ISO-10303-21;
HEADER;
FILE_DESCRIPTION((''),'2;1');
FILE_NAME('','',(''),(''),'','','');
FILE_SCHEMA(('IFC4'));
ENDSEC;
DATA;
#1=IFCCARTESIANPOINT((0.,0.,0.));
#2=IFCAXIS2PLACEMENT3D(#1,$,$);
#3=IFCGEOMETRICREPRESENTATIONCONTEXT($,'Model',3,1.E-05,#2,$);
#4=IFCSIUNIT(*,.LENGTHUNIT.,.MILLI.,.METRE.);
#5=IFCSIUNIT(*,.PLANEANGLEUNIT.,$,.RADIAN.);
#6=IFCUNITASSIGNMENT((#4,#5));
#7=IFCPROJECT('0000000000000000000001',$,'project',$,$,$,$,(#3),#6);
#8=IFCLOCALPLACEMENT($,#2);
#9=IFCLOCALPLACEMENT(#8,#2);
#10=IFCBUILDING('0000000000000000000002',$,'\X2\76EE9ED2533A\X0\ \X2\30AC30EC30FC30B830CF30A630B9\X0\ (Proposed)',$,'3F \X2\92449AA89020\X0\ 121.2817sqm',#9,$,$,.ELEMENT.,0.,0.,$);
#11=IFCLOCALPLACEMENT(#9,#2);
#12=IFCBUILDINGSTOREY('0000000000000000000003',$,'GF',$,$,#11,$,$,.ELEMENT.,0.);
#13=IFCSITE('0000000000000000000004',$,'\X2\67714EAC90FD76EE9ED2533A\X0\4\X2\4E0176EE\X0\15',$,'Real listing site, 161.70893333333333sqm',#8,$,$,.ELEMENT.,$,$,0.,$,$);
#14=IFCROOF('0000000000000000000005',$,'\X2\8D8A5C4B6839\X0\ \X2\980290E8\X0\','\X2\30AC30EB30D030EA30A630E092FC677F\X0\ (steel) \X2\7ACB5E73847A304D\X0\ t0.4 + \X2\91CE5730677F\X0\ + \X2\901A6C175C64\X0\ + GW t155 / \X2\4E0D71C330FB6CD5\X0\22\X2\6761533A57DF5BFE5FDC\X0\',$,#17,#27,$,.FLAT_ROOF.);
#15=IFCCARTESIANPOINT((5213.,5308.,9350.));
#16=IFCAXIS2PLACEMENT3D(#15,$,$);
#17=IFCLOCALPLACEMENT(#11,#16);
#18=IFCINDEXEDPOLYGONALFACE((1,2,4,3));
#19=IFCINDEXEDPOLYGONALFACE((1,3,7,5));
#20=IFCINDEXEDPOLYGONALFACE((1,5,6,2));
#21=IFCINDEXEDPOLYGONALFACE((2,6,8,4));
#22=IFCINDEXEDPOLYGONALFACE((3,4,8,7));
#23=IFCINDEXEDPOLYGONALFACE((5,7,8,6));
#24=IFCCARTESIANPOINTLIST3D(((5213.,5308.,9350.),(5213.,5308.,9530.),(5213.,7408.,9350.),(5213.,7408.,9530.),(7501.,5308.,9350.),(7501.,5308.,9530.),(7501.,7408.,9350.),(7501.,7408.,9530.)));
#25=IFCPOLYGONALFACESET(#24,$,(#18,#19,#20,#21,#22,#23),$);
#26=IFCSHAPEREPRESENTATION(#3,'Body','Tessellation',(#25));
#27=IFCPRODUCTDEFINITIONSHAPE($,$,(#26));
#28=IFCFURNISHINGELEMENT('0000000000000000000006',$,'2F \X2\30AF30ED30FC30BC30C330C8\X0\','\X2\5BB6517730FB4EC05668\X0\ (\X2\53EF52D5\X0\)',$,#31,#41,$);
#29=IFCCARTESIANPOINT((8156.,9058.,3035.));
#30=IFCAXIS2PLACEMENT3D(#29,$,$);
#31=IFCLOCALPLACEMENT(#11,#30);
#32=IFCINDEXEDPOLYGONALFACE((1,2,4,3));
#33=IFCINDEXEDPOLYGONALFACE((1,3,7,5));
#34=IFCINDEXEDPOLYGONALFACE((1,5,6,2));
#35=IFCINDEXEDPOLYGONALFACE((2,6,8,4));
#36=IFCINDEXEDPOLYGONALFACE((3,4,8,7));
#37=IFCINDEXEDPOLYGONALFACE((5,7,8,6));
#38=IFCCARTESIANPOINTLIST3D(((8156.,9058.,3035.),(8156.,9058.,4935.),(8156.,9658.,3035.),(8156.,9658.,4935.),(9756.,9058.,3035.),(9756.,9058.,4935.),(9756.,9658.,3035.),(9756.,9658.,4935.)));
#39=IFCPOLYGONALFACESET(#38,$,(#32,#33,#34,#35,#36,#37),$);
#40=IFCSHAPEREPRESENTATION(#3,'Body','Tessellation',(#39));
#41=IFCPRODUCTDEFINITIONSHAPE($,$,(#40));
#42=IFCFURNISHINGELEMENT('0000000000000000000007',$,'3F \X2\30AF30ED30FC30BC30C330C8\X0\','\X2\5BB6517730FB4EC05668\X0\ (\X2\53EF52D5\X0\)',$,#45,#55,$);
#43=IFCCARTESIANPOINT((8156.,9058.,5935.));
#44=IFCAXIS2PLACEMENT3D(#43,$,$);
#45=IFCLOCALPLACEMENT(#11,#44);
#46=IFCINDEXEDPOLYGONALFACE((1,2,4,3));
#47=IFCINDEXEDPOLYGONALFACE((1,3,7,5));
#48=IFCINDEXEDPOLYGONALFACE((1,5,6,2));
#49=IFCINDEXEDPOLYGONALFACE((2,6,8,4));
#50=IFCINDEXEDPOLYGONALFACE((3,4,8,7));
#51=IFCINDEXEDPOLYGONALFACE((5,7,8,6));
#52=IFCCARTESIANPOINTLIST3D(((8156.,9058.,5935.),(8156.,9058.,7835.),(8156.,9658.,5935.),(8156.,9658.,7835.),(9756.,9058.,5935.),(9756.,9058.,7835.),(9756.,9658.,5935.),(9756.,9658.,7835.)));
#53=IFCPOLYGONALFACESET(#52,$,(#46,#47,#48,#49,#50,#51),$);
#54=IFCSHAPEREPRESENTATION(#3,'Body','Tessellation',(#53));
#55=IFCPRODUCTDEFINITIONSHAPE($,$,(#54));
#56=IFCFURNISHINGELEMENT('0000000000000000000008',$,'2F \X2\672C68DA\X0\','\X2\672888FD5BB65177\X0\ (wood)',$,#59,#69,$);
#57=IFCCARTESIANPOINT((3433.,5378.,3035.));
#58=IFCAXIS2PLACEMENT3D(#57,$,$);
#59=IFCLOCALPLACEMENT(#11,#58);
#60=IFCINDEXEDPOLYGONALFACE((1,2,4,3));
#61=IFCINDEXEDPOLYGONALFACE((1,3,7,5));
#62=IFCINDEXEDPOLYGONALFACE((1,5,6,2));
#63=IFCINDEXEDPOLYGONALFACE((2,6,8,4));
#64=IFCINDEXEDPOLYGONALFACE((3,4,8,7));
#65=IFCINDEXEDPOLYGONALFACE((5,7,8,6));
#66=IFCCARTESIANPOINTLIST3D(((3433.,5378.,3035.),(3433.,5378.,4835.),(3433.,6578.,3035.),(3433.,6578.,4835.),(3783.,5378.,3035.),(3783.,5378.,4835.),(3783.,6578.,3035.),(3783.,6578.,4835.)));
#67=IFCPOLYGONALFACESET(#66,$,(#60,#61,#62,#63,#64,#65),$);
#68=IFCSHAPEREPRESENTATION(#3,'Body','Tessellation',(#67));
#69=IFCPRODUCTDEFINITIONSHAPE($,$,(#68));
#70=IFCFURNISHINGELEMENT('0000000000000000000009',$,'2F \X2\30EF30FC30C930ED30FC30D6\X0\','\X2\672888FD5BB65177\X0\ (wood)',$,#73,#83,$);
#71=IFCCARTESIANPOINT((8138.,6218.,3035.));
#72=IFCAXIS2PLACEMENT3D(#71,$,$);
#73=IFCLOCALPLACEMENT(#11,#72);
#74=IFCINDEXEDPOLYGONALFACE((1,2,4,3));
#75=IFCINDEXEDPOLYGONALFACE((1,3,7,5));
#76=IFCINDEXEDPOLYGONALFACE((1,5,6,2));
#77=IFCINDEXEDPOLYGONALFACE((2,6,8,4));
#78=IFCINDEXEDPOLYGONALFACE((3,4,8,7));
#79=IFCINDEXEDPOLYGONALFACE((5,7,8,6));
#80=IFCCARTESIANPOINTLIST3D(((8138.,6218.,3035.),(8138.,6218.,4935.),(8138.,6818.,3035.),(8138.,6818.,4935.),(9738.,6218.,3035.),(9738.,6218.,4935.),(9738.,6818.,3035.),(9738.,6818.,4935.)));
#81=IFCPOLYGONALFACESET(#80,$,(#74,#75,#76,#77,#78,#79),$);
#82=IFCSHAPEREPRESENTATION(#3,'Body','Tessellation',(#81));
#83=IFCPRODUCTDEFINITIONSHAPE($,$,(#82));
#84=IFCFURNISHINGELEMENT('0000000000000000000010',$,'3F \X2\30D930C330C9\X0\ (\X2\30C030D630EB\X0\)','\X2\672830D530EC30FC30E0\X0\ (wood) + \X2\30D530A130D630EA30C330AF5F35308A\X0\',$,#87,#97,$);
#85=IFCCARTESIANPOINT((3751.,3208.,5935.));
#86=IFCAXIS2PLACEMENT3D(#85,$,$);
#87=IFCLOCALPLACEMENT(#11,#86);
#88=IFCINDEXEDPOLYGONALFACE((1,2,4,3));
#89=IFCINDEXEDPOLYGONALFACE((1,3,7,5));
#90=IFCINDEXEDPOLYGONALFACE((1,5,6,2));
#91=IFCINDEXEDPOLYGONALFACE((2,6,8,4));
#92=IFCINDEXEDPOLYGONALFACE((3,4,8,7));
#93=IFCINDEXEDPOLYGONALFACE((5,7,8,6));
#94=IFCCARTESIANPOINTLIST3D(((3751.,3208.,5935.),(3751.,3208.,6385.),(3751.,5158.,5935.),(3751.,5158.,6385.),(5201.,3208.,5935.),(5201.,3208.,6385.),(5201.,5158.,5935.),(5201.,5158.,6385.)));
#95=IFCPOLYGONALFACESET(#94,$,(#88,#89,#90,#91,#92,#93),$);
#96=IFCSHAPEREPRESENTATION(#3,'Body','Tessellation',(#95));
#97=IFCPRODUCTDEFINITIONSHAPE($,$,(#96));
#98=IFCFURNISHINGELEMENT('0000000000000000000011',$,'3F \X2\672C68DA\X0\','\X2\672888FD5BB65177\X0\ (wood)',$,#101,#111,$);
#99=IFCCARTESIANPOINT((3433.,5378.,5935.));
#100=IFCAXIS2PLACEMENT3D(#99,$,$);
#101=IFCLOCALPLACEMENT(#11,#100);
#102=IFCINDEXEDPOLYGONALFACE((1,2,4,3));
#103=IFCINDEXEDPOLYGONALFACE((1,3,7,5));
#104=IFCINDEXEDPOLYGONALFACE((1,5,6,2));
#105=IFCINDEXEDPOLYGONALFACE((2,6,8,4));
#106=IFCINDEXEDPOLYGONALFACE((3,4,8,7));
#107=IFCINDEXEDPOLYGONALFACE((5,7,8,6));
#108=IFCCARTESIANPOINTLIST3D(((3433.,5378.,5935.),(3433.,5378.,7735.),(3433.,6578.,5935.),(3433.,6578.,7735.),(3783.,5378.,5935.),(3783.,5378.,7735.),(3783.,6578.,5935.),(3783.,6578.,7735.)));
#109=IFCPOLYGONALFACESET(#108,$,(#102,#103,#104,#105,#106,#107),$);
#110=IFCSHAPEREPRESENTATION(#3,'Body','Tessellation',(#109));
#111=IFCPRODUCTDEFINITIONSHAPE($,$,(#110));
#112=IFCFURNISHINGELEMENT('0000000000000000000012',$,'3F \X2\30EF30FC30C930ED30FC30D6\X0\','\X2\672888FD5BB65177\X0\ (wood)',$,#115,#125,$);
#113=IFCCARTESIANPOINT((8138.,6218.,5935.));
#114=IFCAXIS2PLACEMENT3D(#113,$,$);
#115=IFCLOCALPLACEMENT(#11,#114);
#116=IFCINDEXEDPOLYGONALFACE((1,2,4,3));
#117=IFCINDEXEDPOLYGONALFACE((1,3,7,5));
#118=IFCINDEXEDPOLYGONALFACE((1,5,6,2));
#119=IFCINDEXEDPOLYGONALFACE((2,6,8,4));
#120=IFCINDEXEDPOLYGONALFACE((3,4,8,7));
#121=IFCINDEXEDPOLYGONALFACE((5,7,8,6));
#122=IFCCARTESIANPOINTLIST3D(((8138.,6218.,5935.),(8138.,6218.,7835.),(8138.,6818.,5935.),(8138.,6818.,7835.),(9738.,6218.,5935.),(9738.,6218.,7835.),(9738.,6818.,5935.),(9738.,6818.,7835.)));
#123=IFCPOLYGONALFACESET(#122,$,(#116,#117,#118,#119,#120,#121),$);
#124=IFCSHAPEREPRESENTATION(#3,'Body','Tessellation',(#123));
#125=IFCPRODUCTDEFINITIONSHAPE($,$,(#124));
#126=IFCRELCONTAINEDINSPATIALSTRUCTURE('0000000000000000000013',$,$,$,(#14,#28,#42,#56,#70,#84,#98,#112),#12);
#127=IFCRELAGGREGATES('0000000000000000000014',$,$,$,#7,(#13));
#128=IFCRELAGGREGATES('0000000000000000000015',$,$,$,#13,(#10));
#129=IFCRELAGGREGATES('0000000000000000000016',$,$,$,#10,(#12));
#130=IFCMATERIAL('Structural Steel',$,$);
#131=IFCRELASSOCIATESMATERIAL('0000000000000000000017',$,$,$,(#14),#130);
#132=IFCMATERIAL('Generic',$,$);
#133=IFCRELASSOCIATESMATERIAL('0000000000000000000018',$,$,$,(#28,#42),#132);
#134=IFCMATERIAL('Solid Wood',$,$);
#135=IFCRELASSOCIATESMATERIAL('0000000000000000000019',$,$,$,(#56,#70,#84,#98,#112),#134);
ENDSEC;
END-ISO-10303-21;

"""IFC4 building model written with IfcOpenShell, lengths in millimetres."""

from ifc_helpers import new_model, si_unit, frame, frame_2d, origin, place, context, project, spatial, rectangle, extrude, material, element, save


model = new_model("IFC4")

# Units and contexts
model_context = context("Model", 3, precision=1e-05, world=origin())
ifc_project = project(units=[si_unit("LENGTHUNIT", "METRE", prefix="MILLI"), si_unit("PLANEANGLEUNIT", "RADIAN")], contexts=[model_context])

# Site, building, storey
site_placement = place(None, origin())
site = spatial("IfcSite", under=ifc_project, at=site_placement, Name="東京都目黒区4丁目15", ObjectType="Real listing site, 161.70893333333333sqm", CompositionType="ELEMENT", RefElevation=0.0)
building_placement = place(site_placement, origin())
building = spatial("IfcBuilding", under=site, at=building_placement, Name="目黒区 ガレージハウス (Proposed)", ObjectType="3F 鉄骨造 121.2817sqm", CompositionType="ELEMENT", ElevationOfRefHeight=0.0, ElevationOfTerrain=0.0)
storey_placement = place(building_placement, origin())
storey = spatial("IfcBuildingStorey", under=building, at=storey_placement, Name="GF", CompositionType="ELEMENT", Elevation=0.0)

# Shared definitions
ifc_material_1 = material(Name="Solid Wood")

# Roof
ifc_material_2 = material(Name="Structural Steel")
roof_placement = place(storey_placement, frame((5213.0, 5308.0, 9350.0)))
element("IfcRoof", 1, at=roof_placement, inside=storey, material=ifc_material_2, Name="越屋根 頂部", Description="ガルバリウム鋼板 (steel) 立平葺き t0.4 + 野地板 + 通気層 + GW t155 / 不燃・法22条区域対応", PredefinedType="FLAT_ROOF", context=model_context, shape_type="SweptSolid", body=[
    extrude(rectangle(XDim=2288.0, YDim=2100.0, at=frame_2d((1144.0, 1050.0))), frame((5213.0, 5308.0, 9350.0)), (0.0, 0.0, 1.0), 180.0),
])

# Furnishing elements
ifc_material_3 = material(Name="Generic")
furnishing_1_placement = place(storey_placement, frame((8156.0, 9058.0, 3035.0)))
element("IfcFurnishingElement", 2, at=furnishing_1_placement, inside=storey, material=ifc_material_3, Name="2F クローゼット", Description="家具・什器 (可動)", context=model_context, shape_type="SweptSolid", body=[
    extrude(rectangle(XDim=1600.0, YDim=600.0, at=frame_2d((800.0, 300.0))), frame((8156.0, 9058.0, 3035.0)), (0.0, 0.0, 1.0), 1900.0),
])
furnishing_2_placement = place(storey_placement, frame((8156.0, 9058.0, 5935.0)))
element("IfcFurnishingElement", 3, at=furnishing_2_placement, inside=storey, material=ifc_material_3, Name="3F クローゼット", Description="家具・什器 (可動)", context=model_context, shape_type="SweptSolid", body=[
    extrude(rectangle(XDim=1600.0, YDim=600.0, at=frame_2d((800.0, 300.0))), frame((8156.0, 9058.0, 5935.0)), (0.0, 0.0, 1.0), 1900.0),
])
furnishing_3_placement = place(storey_placement, frame((3433.0, 5378.0, 3035.0)))
element("IfcFurnishingElement", 4, at=furnishing_3_placement, inside=storey, material=ifc_material_1, Name="2F 本棚", Description="木製家具 (wood)", context=model_context, shape_type="SweptSolid", body=[
    extrude(rectangle(XDim=350.0, YDim=1200.0, at=frame_2d((175.0, 600.0))), frame((3433.0, 5378.0, 3035.0)), (0.0, 0.0, 1.0), 1800.0),
])
furnishing_4_placement = place(storey_placement, frame((8138.0, 6218.0, 3035.0)))
element("IfcFurnishingElement", 5, at=furnishing_4_placement, inside=storey, material=ifc_material_1, Name="2F ワードローブ", Description="木製家具 (wood)", context=model_context, shape_type="SweptSolid", body=[
    extrude(rectangle(XDim=1600.0, YDim=600.0, at=frame_2d((800.0, 300.0))), frame((8138.0, 6218.0, 3035.0)), (0.0, 0.0, 1.0), 1900.0),
])
furnishing_5_placement = place(storey_placement, frame((3751.0, 3208.0, 5935.0)))
element("IfcFurnishingElement", 6, at=furnishing_5_placement, inside=storey, material=ifc_material_1, Name="3F ベッド (ダブル)", Description="木フレーム (wood) + ファブリック張り", context=model_context, shape_type="SweptSolid", body=[
    extrude(rectangle(XDim=1450.0, YDim=1950.0, at=frame_2d((725.0, 975.0))), frame((3751.0, 3208.0, 5935.0)), (0.0, 0.0, 1.0), 450.0),
])
furnishing_6_placement = place(storey_placement, frame((3433.0, 5378.0, 5935.0)))
element("IfcFurnishingElement", 7, at=furnishing_6_placement, inside=storey, material=ifc_material_1, Name="3F 本棚", Description="木製家具 (wood)", context=model_context, shape_type="SweptSolid", body=[
    extrude(rectangle(XDim=350.0, YDim=1200.0, at=frame_2d((175.0, 600.0))), frame((3433.0, 5378.0, 5935.0)), (0.0, 0.0, 1.0), 1800.0),
])
furnishing_7_placement = place(storey_placement, frame((8138.0, 6218.0, 5935.0)))
element("IfcFurnishingElement", 8, at=furnishing_7_placement, inside=storey, material=ifc_material_1, Name="3F ワードローブ", Description="木製家具 (wood)", context=model_context, shape_type="SweptSolid", body=[
    extrude(rectangle(XDim=1600.0, YDim=600.0, at=frame_2d((800.0, 300.0))), frame((8138.0, 6218.0, 5935.0)), (0.0, 0.0, 1.0), 1900.0),
])

save(model, "model.ifc")
